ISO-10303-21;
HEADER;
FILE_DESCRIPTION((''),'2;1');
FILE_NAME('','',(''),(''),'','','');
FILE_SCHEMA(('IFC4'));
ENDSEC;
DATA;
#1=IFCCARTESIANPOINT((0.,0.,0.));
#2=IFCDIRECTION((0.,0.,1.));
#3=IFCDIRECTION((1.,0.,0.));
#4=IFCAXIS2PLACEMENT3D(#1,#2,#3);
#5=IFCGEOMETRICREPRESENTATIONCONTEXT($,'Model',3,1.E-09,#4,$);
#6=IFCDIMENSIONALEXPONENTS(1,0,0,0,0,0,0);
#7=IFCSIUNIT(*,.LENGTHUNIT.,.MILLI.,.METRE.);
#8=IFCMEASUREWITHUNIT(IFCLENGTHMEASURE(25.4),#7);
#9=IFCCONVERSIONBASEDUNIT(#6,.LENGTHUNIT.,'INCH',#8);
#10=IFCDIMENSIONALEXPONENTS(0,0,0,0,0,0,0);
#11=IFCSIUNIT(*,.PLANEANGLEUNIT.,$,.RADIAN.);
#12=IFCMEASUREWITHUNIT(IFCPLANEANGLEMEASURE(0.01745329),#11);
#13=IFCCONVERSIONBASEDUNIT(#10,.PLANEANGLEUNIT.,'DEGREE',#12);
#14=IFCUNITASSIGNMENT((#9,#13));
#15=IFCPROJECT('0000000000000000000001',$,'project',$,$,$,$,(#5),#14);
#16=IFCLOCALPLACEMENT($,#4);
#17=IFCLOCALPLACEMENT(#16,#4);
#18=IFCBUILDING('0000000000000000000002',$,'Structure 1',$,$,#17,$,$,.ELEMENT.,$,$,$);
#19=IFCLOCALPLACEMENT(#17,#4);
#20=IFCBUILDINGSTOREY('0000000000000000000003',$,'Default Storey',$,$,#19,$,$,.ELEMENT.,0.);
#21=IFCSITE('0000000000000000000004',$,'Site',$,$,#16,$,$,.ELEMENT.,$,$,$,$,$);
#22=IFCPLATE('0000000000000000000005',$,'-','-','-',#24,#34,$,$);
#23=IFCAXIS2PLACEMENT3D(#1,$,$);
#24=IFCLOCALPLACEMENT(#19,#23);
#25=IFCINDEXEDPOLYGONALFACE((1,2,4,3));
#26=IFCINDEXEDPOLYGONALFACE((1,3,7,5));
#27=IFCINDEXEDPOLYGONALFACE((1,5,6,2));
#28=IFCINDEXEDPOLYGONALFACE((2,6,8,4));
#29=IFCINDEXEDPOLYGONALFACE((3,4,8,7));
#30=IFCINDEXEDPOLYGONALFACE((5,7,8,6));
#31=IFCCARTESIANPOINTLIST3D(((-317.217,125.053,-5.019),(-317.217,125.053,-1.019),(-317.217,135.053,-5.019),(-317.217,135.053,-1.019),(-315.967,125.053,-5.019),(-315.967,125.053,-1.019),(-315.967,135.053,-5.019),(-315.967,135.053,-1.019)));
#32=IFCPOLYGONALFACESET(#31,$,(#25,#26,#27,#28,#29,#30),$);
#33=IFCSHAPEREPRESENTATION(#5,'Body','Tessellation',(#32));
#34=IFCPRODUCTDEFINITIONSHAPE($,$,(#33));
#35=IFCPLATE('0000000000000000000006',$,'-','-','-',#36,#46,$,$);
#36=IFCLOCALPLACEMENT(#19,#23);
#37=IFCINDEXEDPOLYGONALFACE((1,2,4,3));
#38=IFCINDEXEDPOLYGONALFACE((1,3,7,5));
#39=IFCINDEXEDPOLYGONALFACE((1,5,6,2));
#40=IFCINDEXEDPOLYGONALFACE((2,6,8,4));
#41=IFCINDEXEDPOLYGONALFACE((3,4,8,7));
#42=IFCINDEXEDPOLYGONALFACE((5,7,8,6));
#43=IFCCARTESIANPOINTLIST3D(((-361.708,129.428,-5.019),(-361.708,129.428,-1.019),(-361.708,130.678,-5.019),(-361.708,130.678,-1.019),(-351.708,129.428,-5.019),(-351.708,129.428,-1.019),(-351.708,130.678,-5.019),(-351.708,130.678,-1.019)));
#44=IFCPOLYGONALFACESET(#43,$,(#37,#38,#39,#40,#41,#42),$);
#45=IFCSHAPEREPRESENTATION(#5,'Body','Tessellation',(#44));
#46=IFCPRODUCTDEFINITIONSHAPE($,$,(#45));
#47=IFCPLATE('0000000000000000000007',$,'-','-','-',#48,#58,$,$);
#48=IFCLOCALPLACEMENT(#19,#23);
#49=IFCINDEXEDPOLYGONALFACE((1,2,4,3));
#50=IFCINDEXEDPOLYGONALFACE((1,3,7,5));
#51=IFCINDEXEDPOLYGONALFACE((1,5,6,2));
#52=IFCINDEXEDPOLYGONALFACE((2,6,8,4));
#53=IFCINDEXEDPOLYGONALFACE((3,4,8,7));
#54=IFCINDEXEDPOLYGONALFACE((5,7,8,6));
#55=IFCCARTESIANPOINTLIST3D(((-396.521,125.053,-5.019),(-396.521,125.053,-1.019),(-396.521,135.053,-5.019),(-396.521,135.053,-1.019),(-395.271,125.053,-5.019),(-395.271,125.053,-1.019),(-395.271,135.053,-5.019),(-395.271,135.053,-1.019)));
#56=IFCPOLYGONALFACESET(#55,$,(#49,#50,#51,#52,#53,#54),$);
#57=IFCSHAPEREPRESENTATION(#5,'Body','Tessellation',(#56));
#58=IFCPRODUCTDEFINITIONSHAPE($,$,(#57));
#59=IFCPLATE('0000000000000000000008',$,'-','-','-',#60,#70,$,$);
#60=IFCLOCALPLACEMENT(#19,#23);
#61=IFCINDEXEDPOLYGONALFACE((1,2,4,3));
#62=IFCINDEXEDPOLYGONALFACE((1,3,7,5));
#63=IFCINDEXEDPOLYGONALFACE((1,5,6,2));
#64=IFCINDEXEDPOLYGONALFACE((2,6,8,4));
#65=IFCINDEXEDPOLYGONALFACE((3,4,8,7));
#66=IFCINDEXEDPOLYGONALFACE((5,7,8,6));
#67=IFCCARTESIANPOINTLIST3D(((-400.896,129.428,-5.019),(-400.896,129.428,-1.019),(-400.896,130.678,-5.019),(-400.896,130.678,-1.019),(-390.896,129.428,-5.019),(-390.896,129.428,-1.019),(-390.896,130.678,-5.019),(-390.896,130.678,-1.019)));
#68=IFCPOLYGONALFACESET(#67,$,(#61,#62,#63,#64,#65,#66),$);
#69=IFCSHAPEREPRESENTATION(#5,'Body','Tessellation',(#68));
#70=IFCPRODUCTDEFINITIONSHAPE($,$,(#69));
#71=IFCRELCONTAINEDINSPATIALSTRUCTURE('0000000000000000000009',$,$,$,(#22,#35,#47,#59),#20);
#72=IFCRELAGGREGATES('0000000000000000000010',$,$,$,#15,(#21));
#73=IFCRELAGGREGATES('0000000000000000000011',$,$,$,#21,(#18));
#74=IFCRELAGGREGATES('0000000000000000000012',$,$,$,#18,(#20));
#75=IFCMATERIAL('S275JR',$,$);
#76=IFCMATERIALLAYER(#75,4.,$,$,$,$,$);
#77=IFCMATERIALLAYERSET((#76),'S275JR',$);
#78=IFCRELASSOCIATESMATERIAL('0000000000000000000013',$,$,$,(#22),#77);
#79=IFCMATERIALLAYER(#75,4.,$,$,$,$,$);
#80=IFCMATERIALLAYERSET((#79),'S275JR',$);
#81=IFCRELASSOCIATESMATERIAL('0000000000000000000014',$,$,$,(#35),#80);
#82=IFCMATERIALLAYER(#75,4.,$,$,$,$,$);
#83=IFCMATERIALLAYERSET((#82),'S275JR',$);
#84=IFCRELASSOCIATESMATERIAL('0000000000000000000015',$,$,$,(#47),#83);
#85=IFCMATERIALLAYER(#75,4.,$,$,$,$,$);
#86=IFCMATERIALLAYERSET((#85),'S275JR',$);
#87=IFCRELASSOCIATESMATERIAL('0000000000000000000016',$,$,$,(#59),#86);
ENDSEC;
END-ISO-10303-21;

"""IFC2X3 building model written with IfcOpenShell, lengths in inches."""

from ifc_helpers import new_model, entity, si_unit, converted_unit, frame, origin_with_axes, place, context, project, spatial, polyline, outline, extrude, material, layer, layer_set, element, save


model = new_model("IFC2X3")

# Units and contexts
model_context = context("Model", 3, precision=1e-09, world=origin_with_axes())
ifc_project = project(units=[converted_unit("LENGTHUNIT", "INCH", entity("IfcLengthMeasure", 25.4), si_unit("LENGTHUNIT", "METRE", prefix="MILLI"), dimensions=[1, 0, 0, 0, 0, 0, 0]), converted_unit("PLANEANGLEUNIT", "DEGREE", entity("IfcPlaneAngleMeasure", 0.01745329), si_unit("PLANEANGLEUNIT", "RADIAN"), dimensions=[0, 0, 0, 0, 0, 0, 0])], contexts=[model_context])

# Site, building, storey
site_placement = place(None, origin_with_axes())
site = spatial("IfcSite", under=ifc_project, at=site_placement, Name="Site", CompositionType="ELEMENT")
building_placement = place(site_placement, origin_with_axes())
building = spatial("IfcBuilding", under=site, at=building_placement, Name="Structure 1", CompositionType="ELEMENT")
storey_placement = place(building_placement, origin_with_axes())
storey = spatial("IfcBuildingStorey", under=building, at=storey_placement, Name="Default Storey", CompositionType="ELEMENT", Elevation=0.0)

# Plates
ifc_material_1 = material(Name="S275JR")
ifc_layer_1 = layer(ifc_material_1, 4.0)
ifc_layer_set_1 = layer_set([ifc_layer_1], Name="S275JR")
plate_1_placement = place(None, frame((-316.592, 130.053, -5.019), z_axis=(0.0, 0.0, 1.0), x_axis=(1.0, 0.0, 0.0)))
element("IfcPlate", 1, at=plate_1_placement, inside=storey, material=ifc_layer_set_1, Name="-", Description="-", ObjectType="-", context=model_context, shape_type="SweptSolid", body=[
    extrude(outline(polyline([(-0.625, -5.0), (0.625, -5.0), (0.625, 5.0), (-0.625, 5.0), (-0.625, -5.0)])), origin_with_axes(), (0.0, 0.0, 1.0), 4.0),
])
ifc_layer_2 = layer(ifc_material_1, 4.0)
ifc_layer_set_2 = layer_set([ifc_layer_2], Name="S275JR")
plate_2_placement = place(None, frame((-356.708, 130.053, -5.019), z_axis=(0.0, 0.0, 1.0), x_axis=(0.0, -1.0, 0.0)))
element("IfcPlate", 2, at=plate_2_placement, inside=storey, material=ifc_layer_set_2, Name="-", Description="-", ObjectType="-", context=model_context, shape_type="SweptSolid", body=[
    extrude(outline(polyline([(-0.625, -5.0), (0.625, -5.0), (0.625, 5.0), (-0.625, 5.0), (-0.625, -5.0)])), origin_with_axes(), (0.0, 0.0, 1.0), 4.0),
])
ifc_layer_3 = layer(ifc_material_1, 4.0)
ifc_layer_set_3 = layer_set([ifc_layer_3], Name="S275JR")
plate_3_placement = place(None, frame((-395.896, 130.053, -5.019), z_axis=(0.0, 0.0, 1.0), x_axis=(1.0, 0.0, 0.0)))
element("IfcPlate", 3, at=plate_3_placement, inside=storey, material=ifc_layer_set_3, Name="-", Description="-", ObjectType="-", context=model_context, shape_type="SweptSolid", body=[
    extrude(outline(polyline([(-0.625, -5.0), (0.625, -5.0), (0.625, 5.0), (-0.625, 5.0), (-0.625, -5.0)])), origin_with_axes(), (0.0, 0.0, 1.0), 4.0),
])
ifc_layer_4 = layer(ifc_material_1, 4.0)
ifc_layer_set_4 = layer_set([ifc_layer_4], Name="S275JR")
plate_4_placement = place(None, frame((-395.896, 130.053, -5.019), z_axis=(0.0, 0.0, 1.0), x_axis=(0.0, -1.0, 0.0)))
element("IfcPlate", 4, at=plate_4_placement, inside=storey, material=ifc_layer_set_4, Name="-", Description="-", ObjectType="-", context=model_context, shape_type="SweptSolid", body=[
    extrude(outline(polyline([(-0.625, -5.0), (0.625, -5.0), (0.625, 5.0), (-0.625, 5.0), (-0.625, -5.0)])), origin_with_axes(), (0.0, 0.0, 1.0), 4.0),
])

save(model, "model.ifc")
